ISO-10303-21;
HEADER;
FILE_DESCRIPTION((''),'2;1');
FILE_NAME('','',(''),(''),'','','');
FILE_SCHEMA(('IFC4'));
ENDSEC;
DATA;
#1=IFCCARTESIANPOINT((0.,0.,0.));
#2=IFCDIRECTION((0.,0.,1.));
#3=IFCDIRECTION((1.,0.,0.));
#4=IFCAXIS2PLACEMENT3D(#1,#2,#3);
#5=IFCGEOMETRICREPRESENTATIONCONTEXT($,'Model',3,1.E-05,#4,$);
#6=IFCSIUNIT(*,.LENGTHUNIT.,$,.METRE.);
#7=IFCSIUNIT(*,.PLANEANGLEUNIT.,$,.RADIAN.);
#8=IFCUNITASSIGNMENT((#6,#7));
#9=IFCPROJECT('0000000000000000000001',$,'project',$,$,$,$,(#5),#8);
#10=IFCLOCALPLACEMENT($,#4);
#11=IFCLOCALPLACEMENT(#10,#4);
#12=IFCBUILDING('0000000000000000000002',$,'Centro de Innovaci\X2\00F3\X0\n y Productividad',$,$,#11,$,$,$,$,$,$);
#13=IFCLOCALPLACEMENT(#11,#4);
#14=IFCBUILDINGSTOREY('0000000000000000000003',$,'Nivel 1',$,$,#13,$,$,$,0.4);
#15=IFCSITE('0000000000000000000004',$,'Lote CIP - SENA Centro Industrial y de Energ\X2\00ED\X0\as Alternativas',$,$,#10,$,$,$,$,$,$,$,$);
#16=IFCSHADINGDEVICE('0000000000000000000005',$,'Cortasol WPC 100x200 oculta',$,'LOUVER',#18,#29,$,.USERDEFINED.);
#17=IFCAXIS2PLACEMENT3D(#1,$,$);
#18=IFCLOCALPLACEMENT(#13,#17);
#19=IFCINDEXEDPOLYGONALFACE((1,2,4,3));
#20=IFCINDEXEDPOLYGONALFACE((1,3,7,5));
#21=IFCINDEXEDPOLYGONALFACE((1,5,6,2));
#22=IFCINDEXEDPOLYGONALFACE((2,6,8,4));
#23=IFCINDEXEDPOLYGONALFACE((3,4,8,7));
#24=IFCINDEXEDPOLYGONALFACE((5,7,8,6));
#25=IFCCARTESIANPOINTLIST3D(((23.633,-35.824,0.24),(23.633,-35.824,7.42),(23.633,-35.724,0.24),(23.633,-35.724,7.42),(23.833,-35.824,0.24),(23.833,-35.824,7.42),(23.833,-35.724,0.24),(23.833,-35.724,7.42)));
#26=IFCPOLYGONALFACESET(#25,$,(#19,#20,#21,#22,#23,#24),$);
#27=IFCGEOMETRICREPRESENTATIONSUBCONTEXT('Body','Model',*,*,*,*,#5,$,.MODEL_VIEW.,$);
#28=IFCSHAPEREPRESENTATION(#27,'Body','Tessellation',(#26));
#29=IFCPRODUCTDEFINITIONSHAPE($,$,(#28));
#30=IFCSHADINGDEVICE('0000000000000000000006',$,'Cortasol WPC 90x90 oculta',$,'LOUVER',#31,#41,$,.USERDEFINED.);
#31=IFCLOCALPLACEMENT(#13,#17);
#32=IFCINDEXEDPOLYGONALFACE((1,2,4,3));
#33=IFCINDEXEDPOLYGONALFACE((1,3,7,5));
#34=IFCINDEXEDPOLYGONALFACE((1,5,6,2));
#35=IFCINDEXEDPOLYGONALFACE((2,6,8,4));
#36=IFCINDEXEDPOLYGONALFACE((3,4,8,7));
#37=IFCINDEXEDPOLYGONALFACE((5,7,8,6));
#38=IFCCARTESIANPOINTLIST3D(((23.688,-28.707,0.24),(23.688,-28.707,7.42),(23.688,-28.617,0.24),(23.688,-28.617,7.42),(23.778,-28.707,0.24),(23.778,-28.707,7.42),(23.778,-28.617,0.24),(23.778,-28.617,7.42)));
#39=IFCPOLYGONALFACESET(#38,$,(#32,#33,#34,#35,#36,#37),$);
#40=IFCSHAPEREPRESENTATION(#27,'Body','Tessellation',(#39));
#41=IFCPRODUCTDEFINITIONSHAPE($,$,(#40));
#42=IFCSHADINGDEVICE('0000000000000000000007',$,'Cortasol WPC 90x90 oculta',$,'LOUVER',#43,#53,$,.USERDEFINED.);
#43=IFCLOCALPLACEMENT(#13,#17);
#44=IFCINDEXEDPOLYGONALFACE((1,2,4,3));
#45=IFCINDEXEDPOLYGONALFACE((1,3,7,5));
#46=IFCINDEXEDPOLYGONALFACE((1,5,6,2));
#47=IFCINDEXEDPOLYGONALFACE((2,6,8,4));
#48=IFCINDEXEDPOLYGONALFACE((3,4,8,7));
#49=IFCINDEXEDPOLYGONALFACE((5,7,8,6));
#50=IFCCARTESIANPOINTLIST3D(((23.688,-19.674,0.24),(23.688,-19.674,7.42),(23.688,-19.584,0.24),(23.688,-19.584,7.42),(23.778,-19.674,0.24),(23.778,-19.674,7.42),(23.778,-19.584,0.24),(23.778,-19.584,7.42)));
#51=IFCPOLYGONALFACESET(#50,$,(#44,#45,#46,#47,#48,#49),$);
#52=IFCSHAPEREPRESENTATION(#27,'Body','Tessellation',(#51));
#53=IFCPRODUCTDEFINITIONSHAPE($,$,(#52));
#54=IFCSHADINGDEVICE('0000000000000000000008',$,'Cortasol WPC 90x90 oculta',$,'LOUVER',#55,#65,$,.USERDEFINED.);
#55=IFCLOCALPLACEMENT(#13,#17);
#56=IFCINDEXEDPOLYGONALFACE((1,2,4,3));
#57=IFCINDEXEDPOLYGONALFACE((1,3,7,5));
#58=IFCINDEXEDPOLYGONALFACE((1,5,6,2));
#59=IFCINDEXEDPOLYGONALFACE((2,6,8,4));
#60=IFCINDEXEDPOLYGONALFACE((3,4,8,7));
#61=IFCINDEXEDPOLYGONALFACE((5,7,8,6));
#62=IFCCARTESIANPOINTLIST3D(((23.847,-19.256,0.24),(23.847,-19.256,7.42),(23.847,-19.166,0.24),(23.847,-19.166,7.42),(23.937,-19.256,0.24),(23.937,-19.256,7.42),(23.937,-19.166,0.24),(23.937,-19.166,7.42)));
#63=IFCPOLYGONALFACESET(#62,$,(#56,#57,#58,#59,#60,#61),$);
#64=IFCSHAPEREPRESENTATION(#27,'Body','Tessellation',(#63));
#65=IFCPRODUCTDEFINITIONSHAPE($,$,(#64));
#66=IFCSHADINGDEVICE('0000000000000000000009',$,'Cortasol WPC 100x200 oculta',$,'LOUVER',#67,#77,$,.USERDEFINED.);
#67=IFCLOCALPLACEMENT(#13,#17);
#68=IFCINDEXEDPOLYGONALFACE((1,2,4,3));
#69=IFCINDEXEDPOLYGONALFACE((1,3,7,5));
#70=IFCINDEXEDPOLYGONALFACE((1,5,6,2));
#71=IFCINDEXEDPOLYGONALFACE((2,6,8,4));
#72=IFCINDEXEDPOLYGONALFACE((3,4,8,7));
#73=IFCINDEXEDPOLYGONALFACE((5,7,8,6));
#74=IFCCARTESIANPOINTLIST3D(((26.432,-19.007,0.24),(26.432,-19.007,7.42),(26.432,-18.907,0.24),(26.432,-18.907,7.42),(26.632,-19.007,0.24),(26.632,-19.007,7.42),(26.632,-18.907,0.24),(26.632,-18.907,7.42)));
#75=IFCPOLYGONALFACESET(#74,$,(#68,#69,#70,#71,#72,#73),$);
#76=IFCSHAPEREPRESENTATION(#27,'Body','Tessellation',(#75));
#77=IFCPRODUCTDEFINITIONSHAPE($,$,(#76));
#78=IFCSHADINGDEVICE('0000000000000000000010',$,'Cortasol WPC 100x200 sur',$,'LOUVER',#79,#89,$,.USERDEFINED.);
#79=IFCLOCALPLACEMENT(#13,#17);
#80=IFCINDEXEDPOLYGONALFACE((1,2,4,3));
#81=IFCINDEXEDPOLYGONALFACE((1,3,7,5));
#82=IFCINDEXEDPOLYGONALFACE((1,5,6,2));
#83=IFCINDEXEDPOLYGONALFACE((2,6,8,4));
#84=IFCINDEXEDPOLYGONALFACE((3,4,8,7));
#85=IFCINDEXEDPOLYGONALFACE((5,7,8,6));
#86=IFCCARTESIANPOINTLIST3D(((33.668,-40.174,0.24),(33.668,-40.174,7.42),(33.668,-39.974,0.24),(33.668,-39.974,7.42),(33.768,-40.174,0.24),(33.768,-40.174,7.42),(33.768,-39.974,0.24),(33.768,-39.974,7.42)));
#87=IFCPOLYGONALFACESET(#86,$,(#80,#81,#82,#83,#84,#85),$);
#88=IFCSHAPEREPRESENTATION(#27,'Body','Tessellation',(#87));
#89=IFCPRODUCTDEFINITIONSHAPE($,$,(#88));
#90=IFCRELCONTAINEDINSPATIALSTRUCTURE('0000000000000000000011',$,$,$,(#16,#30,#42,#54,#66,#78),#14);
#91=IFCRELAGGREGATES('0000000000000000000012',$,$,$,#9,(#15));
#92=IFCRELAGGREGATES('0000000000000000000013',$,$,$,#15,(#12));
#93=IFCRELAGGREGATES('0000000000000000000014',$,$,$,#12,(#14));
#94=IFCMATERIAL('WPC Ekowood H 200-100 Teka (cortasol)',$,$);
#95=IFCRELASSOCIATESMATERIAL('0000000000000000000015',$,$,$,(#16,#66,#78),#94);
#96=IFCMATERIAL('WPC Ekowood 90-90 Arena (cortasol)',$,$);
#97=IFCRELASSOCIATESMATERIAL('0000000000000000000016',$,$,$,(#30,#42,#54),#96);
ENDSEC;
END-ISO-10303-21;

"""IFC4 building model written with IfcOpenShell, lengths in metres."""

from ifc_helpers import new_model, si_unit, frame, origin_with_axes, place, context, subcontext, project, spatial, polyline, outline, extrude, material, element, save


model = new_model("IFC4")

# Units and contexts
model_context = context("Model", 3, precision=1e-05, world=origin_with_axes())
body_context = subcontext(model_context, "Body", "Model", "MODEL_VIEW")
ifc_project = project(units=[si_unit("LENGTHUNIT", "METRE"), si_unit("PLANEANGLEUNIT", "RADIAN")], contexts=[model_context])

# Site, building, storey
site_placement = place(None, origin_with_axes())
site = spatial("IfcSite", under=ifc_project, at=site_placement, Name="Lote CIP - SENA Centro Industrial y de Energías Alternativas")
building_placement = place(site_placement, origin_with_axes())
building = spatial("IfcBuilding", under=site, at=building_placement, Name="Centro de Innovación y Productividad")
storey_placement = place(building_placement, origin_with_axes())
storey = spatial("IfcBuildingStorey", under=building, at=storey_placement, Name="Nivel 1", Elevation=0.4)

# Shading devices
ifc_material_1 = material(Name="WPC Ekowood 90-90 Arena (cortasol)")
ifc_material_2 = material(Name="WPC Ekowood H 200-100 Teka (cortasol)")
shading_device_1_placement = place(storey_placement, origin_with_axes())
element("IfcShadingDevice", 1, at=shading_device_1_placement, inside=storey, material=ifc_material_2, Name="Cortasol WPC 100x200 oculta", ObjectType="LOUVER", PredefinedType="USERDEFINED", context=body_context, shape_type="SweptSolid", body=[
    extrude(outline(polyline([(23.833, -35.824), (23.633, -35.824), (23.633, -35.724), (23.833, -35.724), (23.833, -35.824)])), frame((0.0, 0.0, 0.24)), (0.0, 0.0, 1.0), 7.18),
])
shading_device_2_placement = place(storey_placement, origin_with_axes())
element("IfcShadingDevice", 2, at=shading_device_2_placement, inside=storey, material=ifc_material_1, Name="Cortasol WPC 90x90 oculta", ObjectType="LOUVER", PredefinedType="USERDEFINED", context=body_context, shape_type="SweptSolid", body=[
    extrude(outline(polyline([(23.778, -28.707), (23.688, -28.707), (23.688, -28.617), (23.778, -28.617), (23.778, -28.707)])), frame((0.0, 0.0, 0.24)), (0.0, 0.0, 1.0), 7.18),
])
shading_device_3_placement = place(storey_placement, origin_with_axes())
element("IfcShadingDevice", 3, at=shading_device_3_placement, inside=storey, material=ifc_material_1, Name="Cortasol WPC 90x90 oculta", ObjectType="LOUVER", PredefinedType="USERDEFINED", context=body_context, shape_type="SweptSolid", body=[
    extrude(outline(polyline([(23.778, -19.674), (23.688, -19.674), (23.688, -19.584), (23.778, -19.584), (23.778, -19.674)])), frame((0.0, 0.0, 0.24)), (0.0, 0.0, 1.0), 7.18),
])
shading_device_4_placement = place(storey_placement, origin_with_axes())
element("IfcShadingDevice", 4, at=shading_device_4_placement, inside=storey, material=ifc_material_1, Name="Cortasol WPC 90x90 oculta", ObjectType="LOUVER", PredefinedType="USERDEFINED", context=body_context, shape_type="SweptSolid", body=[
    extrude(outline(polyline([(23.847, -19.256), (23.847, -19.166), (23.937, -19.166), (23.937, -19.256), (23.847, -19.256)])), frame((0.0, 0.0, 0.24)), (0.0, 0.0, 1.0), 7.18),
])
shading_device_5_placement = place(storey_placement, origin_with_axes())
element("IfcShadingDevice", 5, at=shading_device_5_placement, inside=storey, material=ifc_material_2, Name="Cortasol WPC 100x200 oculta", ObjectType="LOUVER", PredefinedType="USERDEFINED", context=body_context, shape_type="SweptSolid", body=[
    extrude(outline(polyline([(26.632, -19.007), (26.432, -19.007), (26.432, -18.907), (26.632, -18.907), (26.632, -19.007)])), frame((0.0, 0.0, 0.24)), (0.0, 0.0, 1.0), 7.18),
])
shading_device_6_placement = place(storey_placement, origin_with_axes())
element("IfcShadingDevice", 6, at=shading_device_6_placement, inside=storey, material=ifc_material_2, Name="Cortasol WPC 100x200 sur", ObjectType="LOUVER", PredefinedType="USERDEFINED", context=body_context, shape_type="SweptSolid", body=[
    extrude(outline(polyline([(33.668, -40.174), (33.668, -39.974), (33.768, -39.974), (33.768, -40.174), (33.668, -40.174)])), frame((0.0, 0.0, 0.24)), (0.0, 0.0, 1.0), 7.18),
])

save(model, "model.ifc")
